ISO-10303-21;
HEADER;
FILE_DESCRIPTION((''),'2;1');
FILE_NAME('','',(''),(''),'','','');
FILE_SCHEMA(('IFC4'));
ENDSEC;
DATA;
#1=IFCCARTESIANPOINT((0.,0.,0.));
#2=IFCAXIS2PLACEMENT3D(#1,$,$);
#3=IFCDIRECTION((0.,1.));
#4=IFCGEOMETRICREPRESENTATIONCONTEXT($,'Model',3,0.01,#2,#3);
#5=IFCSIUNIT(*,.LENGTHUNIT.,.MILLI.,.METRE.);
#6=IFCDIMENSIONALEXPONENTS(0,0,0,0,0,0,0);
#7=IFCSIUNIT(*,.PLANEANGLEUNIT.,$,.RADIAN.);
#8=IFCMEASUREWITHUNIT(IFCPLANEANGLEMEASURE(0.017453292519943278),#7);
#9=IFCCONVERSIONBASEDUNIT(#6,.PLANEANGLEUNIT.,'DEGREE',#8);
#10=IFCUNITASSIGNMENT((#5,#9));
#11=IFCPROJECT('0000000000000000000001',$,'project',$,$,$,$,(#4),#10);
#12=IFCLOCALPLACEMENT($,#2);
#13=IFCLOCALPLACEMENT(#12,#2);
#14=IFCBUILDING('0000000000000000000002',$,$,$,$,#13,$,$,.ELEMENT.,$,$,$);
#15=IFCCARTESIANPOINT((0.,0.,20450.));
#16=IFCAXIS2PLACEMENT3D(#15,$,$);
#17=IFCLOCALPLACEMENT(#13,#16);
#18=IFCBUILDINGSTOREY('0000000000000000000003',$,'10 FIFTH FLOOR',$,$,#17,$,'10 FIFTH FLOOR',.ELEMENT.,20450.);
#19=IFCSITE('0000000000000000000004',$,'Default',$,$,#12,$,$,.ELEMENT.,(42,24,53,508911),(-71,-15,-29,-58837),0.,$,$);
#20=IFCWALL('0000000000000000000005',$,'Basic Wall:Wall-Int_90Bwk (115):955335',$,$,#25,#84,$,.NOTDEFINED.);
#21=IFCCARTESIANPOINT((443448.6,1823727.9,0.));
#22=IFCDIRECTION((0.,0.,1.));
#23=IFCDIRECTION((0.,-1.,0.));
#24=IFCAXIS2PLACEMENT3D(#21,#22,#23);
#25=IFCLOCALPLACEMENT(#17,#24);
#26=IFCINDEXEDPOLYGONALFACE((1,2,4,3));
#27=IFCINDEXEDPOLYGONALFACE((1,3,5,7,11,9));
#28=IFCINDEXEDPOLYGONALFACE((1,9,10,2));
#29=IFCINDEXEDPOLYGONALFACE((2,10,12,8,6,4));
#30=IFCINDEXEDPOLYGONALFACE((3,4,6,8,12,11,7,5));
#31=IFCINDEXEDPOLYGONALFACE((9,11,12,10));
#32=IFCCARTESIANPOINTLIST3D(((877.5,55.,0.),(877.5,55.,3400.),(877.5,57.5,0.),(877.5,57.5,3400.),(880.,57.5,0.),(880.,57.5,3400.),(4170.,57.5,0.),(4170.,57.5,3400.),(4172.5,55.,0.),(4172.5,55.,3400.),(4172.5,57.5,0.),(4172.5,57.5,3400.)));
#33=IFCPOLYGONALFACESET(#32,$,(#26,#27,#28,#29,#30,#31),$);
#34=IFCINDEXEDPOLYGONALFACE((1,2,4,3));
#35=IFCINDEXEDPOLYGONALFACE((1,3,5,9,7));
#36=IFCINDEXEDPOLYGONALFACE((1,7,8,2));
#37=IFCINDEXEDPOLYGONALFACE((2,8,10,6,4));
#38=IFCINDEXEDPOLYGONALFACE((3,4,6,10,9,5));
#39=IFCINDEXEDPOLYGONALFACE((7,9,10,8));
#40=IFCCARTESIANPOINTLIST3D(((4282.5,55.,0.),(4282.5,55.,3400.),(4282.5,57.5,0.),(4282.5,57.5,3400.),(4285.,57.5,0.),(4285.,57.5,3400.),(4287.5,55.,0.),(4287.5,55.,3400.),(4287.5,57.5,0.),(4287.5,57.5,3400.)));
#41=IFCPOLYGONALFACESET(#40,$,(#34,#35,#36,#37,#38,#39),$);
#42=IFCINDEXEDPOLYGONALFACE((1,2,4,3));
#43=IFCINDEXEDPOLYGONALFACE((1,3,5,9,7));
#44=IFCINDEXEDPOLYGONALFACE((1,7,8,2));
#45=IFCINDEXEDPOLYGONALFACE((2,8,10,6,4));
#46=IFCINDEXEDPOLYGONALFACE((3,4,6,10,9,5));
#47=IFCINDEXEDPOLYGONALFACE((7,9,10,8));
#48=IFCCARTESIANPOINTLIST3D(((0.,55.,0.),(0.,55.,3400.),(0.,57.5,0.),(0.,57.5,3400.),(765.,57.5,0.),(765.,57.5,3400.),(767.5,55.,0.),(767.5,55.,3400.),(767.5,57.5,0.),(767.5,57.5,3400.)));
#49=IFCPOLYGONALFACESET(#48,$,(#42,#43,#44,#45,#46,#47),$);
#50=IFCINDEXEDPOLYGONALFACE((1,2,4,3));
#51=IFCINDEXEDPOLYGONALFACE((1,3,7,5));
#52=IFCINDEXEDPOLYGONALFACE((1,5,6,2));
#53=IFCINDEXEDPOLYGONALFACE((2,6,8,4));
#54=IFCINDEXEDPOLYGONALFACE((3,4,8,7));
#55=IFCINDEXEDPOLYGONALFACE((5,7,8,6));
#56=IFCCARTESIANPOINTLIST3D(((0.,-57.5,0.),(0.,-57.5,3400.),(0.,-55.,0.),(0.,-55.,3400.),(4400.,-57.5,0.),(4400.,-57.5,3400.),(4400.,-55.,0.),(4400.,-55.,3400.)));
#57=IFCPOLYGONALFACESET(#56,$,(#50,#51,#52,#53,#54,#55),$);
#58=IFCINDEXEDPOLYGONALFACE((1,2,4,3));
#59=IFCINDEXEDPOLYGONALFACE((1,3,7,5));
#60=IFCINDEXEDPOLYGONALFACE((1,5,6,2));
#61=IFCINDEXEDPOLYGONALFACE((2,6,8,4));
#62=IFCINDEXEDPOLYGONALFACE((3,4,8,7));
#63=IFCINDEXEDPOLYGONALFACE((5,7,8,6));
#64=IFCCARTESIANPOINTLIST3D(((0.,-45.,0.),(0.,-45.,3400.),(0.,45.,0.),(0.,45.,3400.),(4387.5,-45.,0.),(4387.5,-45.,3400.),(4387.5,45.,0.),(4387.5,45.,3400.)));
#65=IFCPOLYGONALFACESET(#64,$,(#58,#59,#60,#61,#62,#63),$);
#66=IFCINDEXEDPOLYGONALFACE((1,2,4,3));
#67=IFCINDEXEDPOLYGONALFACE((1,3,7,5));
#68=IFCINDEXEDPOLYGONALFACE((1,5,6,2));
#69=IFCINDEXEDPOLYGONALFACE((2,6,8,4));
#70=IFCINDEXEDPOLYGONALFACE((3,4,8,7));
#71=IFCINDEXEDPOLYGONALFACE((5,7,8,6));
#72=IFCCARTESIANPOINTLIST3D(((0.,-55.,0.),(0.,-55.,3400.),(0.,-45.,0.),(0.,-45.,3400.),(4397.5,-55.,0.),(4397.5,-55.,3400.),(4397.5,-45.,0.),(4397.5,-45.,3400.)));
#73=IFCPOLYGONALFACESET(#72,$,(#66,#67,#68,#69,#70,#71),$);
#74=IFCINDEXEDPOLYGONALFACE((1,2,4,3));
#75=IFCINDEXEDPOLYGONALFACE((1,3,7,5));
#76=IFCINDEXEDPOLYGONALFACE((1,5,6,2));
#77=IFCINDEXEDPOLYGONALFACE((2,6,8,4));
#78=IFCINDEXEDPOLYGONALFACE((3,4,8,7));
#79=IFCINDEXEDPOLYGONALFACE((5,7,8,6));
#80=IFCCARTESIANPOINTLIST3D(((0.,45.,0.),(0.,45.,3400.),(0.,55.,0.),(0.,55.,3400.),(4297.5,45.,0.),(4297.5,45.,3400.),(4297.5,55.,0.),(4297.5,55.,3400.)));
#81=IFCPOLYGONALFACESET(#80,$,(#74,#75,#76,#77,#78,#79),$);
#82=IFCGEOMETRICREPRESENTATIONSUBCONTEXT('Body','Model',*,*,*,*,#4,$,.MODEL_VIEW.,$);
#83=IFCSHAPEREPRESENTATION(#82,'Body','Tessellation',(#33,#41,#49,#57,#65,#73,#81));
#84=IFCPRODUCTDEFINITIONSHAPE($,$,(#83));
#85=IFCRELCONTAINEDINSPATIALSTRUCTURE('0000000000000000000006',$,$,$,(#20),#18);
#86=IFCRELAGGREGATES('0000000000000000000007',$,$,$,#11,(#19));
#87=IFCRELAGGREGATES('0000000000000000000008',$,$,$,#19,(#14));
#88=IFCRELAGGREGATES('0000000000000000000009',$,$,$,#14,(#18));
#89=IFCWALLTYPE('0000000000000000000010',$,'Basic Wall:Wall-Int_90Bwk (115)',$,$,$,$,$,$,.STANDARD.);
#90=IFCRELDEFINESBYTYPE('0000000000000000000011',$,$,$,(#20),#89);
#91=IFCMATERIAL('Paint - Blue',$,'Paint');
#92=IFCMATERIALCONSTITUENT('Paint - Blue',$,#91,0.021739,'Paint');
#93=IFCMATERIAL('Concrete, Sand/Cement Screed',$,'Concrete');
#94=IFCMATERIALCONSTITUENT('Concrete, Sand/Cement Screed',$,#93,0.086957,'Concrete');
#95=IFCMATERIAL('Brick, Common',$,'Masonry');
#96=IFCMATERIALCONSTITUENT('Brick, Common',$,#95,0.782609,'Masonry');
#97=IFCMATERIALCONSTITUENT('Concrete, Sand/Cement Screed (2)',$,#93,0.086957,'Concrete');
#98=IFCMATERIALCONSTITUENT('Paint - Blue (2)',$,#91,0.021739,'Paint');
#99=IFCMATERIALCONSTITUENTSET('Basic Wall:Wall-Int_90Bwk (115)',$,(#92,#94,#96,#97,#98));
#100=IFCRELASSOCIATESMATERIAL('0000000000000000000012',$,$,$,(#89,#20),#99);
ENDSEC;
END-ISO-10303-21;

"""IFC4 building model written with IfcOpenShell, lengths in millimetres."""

from ifc_helpers import new_model, entity, si_unit, converted_unit, direction, frame, origin, place, context, subcontext, project, spatial, indexed_curve, outline, extrude, material, constituent, constituent_set, type_object, element, save


model = new_model("IFC4")

# Units and contexts
model_context = context("Model", 3, precision=0.01, world=origin(), true_north=direction((0.0, 1.0)))
body_context = subcontext(model_context, "Body", "Model", "MODEL_VIEW")
ifc_project = project(units=[si_unit("LENGTHUNIT", "METRE", prefix="MILLI"), converted_unit("PLANEANGLEUNIT", "DEGREE", entity("IfcPlaneAngleMeasure", 0.017453292519943278), si_unit("PLANEANGLEUNIT", "RADIAN"), dimensions=[0, 0, 0, 0, 0, 0, 0])], contexts=[model_context])

# Site, building, storey
site_placement = place(None, origin())
site = spatial("IfcSite", under=ifc_project, at=site_placement, Name="Default", CompositionType="ELEMENT", RefLatitude=(42, 24, 53, 508911), RefLongitude=(-71, -15, -29, -58837), RefElevation=0.0)
building_placement = place(site_placement, origin())
building = spatial("IfcBuilding", under=site, at=building_placement, CompositionType="ELEMENT")
storey_placement = place(building_placement, frame((0.0, 0.0, 20450.0)))
storey = spatial("IfcBuildingStorey", under=building, at=storey_placement, Name="10 FIFTH FLOOR", LongName="10 FIFTH FLOOR", CompositionType="ELEMENT", Elevation=20450.0)

# Wall
ifc_material_1 = material(Name="Paint - Blue", Category="Paint")
ifc_constituent_1 = constituent(ifc_material_1, Name="Paint - Blue", Category="Paint", fraction=0.021739)
ifc_material_2 = material(Name="Concrete, Sand/Cement Screed", Category="Concrete")
ifc_constituent_2 = constituent(ifc_material_2, Name="Concrete, Sand/Cement Screed", Category="Concrete", fraction=0.086957)
ifc_material_3 = material(Name="Brick, Common", Category="Masonry")
ifc_constituent_3 = constituent(ifc_material_3, Name="Brick, Common", Category="Masonry", fraction=0.782609)
ifc_constituent_4 = constituent(ifc_material_2, Name="Concrete, Sand/Cement Screed (2)", Category="Concrete", fraction=0.086957)
ifc_constituent_5 = constituent(ifc_material_1, Name="Paint - Blue (2)", Category="Paint", fraction=0.021739)
ifc_constituent_set_1 = constituent_set(constituents=[ifc_constituent_1, ifc_constituent_2, ifc_constituent_3, ifc_constituent_4, ifc_constituent_5], Name="Basic Wall:Wall-Int_90Bwk (115)")
wall_type_1 = type_object("IfcWallType", Name="Basic Wall:Wall-Int_90Bwk (115)", PredefinedType="STANDARD", material=ifc_constituent_set_1)
wall_1_placement = place(storey_placement, frame((443448.6, 1823727.9, 0.0), z_axis=(0.0, 0.0, 1.0), x_axis=(0.0, -1.0, 0.0)))
element("IfcWall", 1, at=wall_1_placement, inside=storey, type_object=wall_type_1, material=ifc_constituent_set_1, Name="Basic Wall:Wall-Int_90Bwk (115):955335", PredefinedType="NOTDEFINED", context=body_context, shape_type="SweptSolid", body=[
    extrude(outline(indexed_curve([(1645.0, -0.8), (1647.5, -0.8), (1647.5, 1.7), (-1647.5, 1.7), (-1647.5, -0.8), (-1645.0, -0.8), (1645.0, -0.8)], self_intersect=False)), frame((2525.0, 56.7, 0.0), z_axis=(0.0, 0.0, 1.0), x_axis=(-1.0, 0.0, 0.0)), (0.0, 0.0, 1.0), 3400.0),
    extrude(outline(indexed_curve([(0.0, -1.0), (2.5, -1.0), (2.5, 1.5), (-2.5, 1.5), (-2.5, -1.0), (0.0, -1.0)], self_intersect=False)), frame((4285.0, 56.5, 0.0), z_axis=(0.0, 0.0, 1.0), x_axis=(-1.0, 0.0, 0.0)), (0.0, 0.0, 1.0), 3400.0),
    extrude(outline(indexed_curve([(-460.0, -1.5), (307.5, -1.5), (307.5, 1.0), (305.0, 1.0), (-460.0, 1.0), (-460.0, -1.5)], self_intersect=False)), frame((460.0, 56.5, 0.0)), (0.0, 0.0, 1.0), 3400.0),
    extrude(outline(indexed_curve([(-1.3, -2200.0), (1.2, -2200.0), (1.2, 2200.0), (-1.3, 2200.0), (-1.3, -2200.0)], self_intersect=False)), frame((2200.0, -56.2, 0.0), z_axis=(0.0, 0.0, 1.0), x_axis=(0.0, 1.0, 0.0)), (0.0, 0.0, 1.0), 3400.0),
    extrude(outline(indexed_curve([(-2193.7, -45.0), (2193.7, -45.0), (2193.7, 45.0), (-2193.7, 45.0), (-2193.7, -45.0)], self_intersect=False)), frame((2193.7, 0.0, 0.0)), (0.0, 0.0, 1.0), 3400.0),
    extrude(outline(indexed_curve([(-2198.7, -5.0), (2198.7, -5.0), (2198.7, 5.0), (-2198.7, 5.0), (-2198.7, -5.0)], self_intersect=False)), frame((2198.7, -50.0, 0.0)), (0.0, 0.0, 1.0), 3400.0),
    extrude(outline(indexed_curve([(-2148.7, -5.0), (2148.7, -5.0), (2148.7, 5.0), (-2148.7, 5.0), (-2148.7, -5.0)], self_intersect=False)), frame((2148.7, 50.0, 0.0)), (0.0, 0.0, 1.0), 3400.0),
])

save(model, "model.ifc")
